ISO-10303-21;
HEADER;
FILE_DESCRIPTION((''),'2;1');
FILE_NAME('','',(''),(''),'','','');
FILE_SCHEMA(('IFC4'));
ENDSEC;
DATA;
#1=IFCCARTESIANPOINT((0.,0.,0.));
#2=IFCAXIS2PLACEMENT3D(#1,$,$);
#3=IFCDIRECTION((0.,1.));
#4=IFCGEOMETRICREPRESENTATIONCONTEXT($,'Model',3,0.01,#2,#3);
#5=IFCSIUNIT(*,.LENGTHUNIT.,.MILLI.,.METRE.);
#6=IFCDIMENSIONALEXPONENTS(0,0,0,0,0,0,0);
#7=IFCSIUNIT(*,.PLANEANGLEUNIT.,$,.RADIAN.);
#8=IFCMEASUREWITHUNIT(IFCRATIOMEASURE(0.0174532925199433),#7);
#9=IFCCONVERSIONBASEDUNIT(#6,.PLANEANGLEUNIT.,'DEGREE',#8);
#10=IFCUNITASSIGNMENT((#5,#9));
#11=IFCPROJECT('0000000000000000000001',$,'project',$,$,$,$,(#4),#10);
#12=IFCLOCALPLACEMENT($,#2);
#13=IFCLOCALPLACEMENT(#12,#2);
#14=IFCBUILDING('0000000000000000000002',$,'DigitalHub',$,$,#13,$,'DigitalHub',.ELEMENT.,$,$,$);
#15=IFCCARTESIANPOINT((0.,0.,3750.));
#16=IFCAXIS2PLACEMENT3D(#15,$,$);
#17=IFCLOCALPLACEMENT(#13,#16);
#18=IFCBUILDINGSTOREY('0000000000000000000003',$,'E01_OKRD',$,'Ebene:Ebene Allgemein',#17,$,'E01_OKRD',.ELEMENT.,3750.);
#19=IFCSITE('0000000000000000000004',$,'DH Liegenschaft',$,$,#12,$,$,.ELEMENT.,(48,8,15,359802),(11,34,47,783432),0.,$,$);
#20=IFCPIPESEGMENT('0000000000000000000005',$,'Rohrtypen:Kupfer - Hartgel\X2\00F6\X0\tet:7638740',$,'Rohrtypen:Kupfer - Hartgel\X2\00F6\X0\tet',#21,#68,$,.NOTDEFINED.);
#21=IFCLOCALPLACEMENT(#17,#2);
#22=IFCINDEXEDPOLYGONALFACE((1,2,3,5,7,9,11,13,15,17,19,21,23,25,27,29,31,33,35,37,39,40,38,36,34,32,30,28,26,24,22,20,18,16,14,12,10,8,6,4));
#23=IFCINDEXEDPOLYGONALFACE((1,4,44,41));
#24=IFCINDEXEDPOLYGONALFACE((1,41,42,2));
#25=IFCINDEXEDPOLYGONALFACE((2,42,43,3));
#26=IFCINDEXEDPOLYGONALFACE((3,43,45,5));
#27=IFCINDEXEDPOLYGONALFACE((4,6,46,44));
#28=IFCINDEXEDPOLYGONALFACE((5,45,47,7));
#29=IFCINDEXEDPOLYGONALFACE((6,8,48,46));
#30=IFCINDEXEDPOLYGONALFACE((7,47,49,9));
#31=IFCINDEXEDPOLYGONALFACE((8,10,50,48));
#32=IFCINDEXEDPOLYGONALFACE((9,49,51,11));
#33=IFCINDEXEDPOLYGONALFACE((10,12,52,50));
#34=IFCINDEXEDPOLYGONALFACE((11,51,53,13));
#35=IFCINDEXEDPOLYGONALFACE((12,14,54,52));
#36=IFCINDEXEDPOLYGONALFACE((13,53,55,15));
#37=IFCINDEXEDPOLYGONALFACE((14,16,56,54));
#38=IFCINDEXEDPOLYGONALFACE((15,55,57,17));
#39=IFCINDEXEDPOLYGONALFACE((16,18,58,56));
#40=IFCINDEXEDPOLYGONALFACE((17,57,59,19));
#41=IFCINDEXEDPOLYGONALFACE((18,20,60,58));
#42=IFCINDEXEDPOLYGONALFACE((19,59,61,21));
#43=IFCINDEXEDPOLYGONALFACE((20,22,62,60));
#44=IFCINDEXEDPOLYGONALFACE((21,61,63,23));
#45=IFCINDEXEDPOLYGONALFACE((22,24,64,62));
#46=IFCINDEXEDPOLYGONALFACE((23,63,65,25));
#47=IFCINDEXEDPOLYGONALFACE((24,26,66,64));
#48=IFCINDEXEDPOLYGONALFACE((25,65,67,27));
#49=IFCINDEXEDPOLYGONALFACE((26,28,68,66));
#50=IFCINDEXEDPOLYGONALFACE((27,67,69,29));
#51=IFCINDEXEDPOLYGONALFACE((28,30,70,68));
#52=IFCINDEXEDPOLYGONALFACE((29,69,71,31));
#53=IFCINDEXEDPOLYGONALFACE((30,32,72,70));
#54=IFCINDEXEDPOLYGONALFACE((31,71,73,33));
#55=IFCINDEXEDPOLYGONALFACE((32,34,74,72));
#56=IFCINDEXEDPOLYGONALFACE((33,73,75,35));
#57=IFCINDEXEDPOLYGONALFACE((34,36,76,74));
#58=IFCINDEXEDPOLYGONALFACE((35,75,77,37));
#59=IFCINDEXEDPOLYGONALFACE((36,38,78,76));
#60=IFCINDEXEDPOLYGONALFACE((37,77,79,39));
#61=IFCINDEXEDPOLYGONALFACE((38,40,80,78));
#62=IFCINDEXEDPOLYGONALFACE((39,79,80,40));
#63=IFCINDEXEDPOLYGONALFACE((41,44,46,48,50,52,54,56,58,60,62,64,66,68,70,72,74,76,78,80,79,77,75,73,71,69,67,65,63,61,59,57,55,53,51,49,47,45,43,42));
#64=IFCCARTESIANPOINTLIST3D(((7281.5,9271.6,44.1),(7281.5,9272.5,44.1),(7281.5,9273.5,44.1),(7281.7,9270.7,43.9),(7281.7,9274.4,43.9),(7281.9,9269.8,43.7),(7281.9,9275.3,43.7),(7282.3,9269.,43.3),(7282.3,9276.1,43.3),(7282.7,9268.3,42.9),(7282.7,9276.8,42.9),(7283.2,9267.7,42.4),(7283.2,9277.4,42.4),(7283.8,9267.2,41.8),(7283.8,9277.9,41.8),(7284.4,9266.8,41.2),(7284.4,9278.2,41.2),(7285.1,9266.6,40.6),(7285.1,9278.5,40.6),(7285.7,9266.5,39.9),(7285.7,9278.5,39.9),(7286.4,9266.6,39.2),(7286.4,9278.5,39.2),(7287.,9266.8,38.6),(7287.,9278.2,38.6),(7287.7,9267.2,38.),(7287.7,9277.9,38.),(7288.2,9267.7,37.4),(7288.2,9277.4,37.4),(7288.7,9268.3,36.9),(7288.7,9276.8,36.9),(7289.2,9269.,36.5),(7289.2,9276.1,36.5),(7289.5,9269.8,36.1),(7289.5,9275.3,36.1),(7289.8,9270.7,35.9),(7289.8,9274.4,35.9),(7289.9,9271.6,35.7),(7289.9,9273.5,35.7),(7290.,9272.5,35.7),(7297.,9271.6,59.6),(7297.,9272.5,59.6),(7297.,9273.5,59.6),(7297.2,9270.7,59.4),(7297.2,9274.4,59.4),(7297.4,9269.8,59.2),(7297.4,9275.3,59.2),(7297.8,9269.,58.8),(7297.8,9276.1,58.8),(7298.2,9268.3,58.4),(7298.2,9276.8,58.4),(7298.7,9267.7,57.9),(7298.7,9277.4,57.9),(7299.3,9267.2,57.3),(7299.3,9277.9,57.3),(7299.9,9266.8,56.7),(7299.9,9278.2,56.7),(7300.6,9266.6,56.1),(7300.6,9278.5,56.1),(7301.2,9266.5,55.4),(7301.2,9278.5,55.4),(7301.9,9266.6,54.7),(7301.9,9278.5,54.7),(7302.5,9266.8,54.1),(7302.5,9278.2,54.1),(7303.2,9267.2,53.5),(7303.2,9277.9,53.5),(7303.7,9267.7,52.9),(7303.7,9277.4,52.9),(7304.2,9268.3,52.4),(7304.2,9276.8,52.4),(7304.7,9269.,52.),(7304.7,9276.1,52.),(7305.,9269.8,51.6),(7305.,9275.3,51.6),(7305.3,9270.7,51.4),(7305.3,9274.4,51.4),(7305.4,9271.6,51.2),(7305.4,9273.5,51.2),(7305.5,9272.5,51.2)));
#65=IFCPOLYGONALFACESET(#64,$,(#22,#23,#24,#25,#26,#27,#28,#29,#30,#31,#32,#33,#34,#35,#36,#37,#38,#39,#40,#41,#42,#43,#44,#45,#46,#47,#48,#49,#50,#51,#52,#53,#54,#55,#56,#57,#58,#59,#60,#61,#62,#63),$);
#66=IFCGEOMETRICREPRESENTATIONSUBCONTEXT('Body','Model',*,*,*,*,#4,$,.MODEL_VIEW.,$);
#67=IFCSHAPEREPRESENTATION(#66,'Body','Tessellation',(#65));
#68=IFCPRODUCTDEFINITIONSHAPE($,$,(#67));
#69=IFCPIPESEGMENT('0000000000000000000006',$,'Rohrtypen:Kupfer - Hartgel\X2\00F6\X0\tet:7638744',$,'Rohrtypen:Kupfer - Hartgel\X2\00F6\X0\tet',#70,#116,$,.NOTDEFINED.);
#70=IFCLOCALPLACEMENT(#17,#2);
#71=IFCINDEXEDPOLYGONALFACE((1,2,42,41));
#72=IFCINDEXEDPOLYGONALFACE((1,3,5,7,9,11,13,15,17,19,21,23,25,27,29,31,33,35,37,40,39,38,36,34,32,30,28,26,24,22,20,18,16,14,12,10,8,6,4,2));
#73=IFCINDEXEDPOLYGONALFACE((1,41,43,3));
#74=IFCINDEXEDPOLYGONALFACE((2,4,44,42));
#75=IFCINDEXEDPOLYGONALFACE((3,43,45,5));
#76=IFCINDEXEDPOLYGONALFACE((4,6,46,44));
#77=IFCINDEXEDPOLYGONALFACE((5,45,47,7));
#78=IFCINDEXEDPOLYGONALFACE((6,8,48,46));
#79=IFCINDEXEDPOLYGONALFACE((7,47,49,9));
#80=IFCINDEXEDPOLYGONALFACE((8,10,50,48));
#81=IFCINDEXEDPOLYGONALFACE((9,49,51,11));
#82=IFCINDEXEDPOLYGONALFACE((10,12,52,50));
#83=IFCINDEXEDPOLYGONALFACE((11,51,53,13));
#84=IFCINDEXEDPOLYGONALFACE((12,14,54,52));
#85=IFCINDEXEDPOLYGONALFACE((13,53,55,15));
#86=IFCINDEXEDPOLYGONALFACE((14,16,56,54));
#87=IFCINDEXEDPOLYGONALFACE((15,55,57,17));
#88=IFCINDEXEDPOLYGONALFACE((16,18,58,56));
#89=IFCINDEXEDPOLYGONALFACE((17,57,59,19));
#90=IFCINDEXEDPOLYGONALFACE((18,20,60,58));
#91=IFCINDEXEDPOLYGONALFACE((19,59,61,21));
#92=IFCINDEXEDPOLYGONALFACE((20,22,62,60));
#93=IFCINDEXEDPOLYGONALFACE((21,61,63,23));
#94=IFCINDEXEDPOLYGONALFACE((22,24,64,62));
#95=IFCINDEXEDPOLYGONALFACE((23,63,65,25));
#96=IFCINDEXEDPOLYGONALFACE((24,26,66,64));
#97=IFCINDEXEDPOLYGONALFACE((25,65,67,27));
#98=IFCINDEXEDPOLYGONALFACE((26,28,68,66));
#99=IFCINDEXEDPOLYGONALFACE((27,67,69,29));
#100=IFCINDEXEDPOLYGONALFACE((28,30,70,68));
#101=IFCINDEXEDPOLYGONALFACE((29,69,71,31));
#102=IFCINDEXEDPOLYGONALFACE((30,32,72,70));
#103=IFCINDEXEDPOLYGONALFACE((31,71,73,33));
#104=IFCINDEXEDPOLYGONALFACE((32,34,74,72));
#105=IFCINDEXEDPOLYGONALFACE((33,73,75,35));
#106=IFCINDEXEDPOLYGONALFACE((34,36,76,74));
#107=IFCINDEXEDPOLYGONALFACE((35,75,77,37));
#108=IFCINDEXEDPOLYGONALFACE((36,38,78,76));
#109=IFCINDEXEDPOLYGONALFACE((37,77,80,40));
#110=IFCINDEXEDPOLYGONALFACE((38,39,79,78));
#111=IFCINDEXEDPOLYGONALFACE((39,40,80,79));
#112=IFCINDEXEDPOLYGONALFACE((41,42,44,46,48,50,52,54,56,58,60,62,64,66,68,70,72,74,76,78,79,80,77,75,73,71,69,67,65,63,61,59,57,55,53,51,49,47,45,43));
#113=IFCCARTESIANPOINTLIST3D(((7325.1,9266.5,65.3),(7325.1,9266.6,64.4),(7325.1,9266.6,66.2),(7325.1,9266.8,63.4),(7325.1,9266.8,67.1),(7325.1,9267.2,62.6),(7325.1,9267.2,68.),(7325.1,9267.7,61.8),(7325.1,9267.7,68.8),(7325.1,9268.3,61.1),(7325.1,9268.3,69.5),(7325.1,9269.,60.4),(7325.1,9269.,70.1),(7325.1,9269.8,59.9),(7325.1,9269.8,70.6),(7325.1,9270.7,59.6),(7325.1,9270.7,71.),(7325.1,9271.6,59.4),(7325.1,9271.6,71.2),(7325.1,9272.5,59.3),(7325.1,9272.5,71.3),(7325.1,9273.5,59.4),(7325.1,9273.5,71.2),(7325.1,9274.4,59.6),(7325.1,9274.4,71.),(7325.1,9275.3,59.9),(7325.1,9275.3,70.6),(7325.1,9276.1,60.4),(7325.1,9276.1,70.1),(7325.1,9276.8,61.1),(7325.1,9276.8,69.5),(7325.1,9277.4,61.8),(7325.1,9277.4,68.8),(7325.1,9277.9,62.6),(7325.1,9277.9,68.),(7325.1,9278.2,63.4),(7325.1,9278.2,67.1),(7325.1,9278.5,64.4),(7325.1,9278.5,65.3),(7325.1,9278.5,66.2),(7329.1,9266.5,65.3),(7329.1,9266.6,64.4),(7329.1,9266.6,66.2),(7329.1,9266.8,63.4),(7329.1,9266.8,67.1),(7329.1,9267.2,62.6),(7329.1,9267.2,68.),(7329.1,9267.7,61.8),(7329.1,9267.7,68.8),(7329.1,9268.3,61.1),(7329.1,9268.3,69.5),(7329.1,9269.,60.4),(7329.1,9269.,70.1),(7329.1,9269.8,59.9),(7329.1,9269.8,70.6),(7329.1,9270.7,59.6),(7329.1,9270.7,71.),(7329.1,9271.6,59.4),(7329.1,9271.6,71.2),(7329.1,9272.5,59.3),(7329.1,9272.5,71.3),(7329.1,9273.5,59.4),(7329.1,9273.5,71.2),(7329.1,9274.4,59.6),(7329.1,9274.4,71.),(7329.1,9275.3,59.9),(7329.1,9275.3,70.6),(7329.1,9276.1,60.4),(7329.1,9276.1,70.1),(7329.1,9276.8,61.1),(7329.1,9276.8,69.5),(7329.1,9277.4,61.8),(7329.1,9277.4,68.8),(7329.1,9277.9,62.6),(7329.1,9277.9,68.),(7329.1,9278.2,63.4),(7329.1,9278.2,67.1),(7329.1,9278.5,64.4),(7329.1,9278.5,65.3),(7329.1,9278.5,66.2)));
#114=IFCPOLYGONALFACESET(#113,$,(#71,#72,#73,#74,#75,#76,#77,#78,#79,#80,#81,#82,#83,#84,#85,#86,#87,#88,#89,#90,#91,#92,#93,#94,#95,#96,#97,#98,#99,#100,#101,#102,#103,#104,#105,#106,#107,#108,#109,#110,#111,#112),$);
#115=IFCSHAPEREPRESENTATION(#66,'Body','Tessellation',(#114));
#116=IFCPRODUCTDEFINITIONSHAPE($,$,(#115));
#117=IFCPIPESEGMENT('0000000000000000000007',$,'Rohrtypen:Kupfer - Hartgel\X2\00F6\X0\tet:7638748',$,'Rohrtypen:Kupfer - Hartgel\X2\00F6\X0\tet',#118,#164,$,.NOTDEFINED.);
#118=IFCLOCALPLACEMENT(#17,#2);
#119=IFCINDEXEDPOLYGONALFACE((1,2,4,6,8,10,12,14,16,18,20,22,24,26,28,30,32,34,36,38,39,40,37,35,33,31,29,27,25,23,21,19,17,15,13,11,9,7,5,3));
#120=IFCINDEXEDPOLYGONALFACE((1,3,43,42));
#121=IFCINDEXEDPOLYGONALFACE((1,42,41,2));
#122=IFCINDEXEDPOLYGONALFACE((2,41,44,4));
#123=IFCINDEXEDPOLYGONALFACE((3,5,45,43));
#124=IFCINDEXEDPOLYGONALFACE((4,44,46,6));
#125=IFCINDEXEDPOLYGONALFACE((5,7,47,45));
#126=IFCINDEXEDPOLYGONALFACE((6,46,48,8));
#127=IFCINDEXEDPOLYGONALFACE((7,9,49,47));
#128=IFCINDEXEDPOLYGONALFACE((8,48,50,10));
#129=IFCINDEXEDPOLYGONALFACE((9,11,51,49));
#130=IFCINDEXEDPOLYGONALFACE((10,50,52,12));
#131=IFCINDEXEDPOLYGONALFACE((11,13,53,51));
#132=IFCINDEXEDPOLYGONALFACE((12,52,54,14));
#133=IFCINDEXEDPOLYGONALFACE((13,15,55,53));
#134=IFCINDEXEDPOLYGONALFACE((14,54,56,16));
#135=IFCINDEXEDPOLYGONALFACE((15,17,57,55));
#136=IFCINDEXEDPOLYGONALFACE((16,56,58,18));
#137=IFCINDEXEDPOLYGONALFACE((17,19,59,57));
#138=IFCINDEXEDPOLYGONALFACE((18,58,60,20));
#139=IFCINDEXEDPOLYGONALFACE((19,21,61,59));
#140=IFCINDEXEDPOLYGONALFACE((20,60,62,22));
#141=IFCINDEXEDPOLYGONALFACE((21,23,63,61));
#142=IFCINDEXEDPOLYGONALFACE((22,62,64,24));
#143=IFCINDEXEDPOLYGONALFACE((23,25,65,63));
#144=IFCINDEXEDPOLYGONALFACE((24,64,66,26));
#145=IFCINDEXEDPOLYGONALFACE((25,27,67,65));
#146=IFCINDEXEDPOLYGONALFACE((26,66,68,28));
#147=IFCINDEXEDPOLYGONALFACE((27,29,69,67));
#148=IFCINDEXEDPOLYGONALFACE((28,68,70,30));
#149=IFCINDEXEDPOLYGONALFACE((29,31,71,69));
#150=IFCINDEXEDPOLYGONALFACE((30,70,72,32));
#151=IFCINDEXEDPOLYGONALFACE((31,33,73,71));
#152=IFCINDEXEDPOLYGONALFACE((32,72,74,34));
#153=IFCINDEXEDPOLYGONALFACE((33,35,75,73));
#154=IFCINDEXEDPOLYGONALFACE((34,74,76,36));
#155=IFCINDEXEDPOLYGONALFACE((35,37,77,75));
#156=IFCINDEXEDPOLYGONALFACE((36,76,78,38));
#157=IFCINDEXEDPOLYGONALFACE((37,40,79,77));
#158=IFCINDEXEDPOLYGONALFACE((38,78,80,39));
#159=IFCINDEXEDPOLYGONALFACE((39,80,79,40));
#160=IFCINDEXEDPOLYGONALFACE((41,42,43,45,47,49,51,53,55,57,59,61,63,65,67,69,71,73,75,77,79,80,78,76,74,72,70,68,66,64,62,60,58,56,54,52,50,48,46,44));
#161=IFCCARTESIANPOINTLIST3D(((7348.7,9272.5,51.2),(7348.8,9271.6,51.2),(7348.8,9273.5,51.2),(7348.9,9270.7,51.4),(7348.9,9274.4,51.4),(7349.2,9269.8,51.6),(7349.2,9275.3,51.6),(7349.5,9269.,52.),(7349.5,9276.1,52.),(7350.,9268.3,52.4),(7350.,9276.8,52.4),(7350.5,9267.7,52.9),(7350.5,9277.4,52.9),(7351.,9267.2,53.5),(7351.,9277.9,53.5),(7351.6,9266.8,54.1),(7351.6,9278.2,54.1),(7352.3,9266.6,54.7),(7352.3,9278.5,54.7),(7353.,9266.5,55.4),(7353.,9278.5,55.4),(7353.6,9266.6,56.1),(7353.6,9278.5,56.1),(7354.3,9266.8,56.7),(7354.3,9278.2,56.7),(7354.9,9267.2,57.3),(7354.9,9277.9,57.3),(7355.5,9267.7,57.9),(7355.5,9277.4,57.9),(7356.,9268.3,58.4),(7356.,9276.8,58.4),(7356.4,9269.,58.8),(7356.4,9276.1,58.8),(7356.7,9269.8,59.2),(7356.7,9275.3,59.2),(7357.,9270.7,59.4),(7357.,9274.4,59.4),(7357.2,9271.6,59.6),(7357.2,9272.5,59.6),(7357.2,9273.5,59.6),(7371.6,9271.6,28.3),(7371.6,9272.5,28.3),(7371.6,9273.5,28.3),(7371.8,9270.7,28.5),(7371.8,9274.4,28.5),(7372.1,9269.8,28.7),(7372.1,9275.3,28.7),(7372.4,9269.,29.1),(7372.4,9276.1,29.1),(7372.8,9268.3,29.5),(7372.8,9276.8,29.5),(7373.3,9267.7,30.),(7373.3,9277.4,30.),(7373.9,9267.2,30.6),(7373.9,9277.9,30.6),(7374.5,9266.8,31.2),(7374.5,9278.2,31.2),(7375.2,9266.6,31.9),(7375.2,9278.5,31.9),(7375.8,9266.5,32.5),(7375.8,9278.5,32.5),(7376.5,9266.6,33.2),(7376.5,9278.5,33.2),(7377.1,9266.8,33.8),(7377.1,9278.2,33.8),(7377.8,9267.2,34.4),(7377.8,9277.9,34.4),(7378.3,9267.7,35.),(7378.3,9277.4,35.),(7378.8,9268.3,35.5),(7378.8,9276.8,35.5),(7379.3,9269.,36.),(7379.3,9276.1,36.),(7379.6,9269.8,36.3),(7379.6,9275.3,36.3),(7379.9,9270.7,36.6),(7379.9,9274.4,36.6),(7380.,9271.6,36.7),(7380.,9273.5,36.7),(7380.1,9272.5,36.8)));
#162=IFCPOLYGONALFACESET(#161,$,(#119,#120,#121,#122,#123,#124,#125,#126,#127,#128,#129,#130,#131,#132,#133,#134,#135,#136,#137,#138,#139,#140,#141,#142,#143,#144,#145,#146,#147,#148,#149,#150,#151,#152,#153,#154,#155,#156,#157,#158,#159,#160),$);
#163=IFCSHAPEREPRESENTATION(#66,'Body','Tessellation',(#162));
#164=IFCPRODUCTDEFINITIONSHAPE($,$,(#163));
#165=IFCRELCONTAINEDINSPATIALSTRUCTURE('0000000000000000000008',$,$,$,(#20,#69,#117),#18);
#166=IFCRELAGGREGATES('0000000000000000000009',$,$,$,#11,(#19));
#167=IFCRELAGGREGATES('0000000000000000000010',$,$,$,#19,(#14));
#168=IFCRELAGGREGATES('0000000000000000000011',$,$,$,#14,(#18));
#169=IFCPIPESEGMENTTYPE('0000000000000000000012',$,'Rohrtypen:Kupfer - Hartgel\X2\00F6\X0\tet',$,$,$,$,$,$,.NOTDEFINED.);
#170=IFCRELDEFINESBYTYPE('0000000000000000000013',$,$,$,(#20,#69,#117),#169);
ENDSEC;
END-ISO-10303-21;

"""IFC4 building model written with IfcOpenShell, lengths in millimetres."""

from ifc_helpers import new_model, entity, si_unit, converted_unit, direction, frame, origin, place, context, subcontext, project, spatial, indexed_curve, outline, extrude, type_object, element, save


model = new_model("IFC4")

# Units and contexts
model_context = context("Model", 3, precision=0.01, world=origin(), true_north=direction((0.0, 1.0)))
body_context = subcontext(model_context, "Body", "Model", "MODEL_VIEW")
ifc_project = project(units=[si_unit("LENGTHUNIT", "METRE", prefix="MILLI"), converted_unit("PLANEANGLEUNIT", "DEGREE", entity("IfcRatioMeasure", 0.0174532925199433), si_unit("PLANEANGLEUNIT", "RADIAN"), dimensions=[0, 0, 0, 0, 0, 0, 0])], contexts=[model_context])

# Site, building, storey
site_placement = place(None, origin())
site = spatial("IfcSite", under=ifc_project, at=site_placement, Name="DH Liegenschaft", CompositionType="ELEMENT", RefLatitude=(48, 8, 15, 359802), RefLongitude=(11, 34, 47, 783432), RefElevation=0.0)
building_placement = place(site_placement, origin())
building = spatial("IfcBuilding", under=site, at=building_placement, Name="DigitalHub", LongName="DigitalHub", CompositionType="ELEMENT")
storey_placement = place(building_placement, frame((0.0, 0.0, 3750.0)))
storey = spatial("IfcBuildingStorey", under=building, at=storey_placement, Name="E01_OKRD", ObjectType="Ebene:Ebene Allgemein", LongName="E01_OKRD", CompositionType="ELEMENT", Elevation=3750.0)

# Pipe segments
pipe_segment_type = type_object("IfcPipeSegmentType", Name="Rohrtypen:Kupfer - Hartgelötet", PredefinedType="NOTDEFINED")
pipe_segment_1_placement = place(storey_placement, frame((7279.9, 9264.9, 34.1)))
element("IfcPipeSegment", 1, at=pipe_segment_1_placement, inside=storey, type_object=pipe_segment_type, Name="Rohrtypen:Kupfer - Hartgelötet:7638740", ObjectType="Rohrtypen:Kupfer - Hartgelötet", PredefinedType="NOTDEFINED", context=body_context, shape_type="SweptSolid", body=[
    extrude(outline(indexed_curve([(6.0, 0.0), (5.9, 0.9), (5.7, 1.9), (5.3, 2.7), (4.9, 3.5), (4.2, 4.2), (3.5, 4.9), (2.7, 5.3), (1.9, 5.7), (0.9, 5.9), (0.0, 6.0), (-0.9, 5.9), (-1.9, 5.7), (-2.7, 5.3), (-3.5, 4.9), (-4.2, 4.2), (-4.9, 3.5), (-5.3, 2.7), (-5.7, 1.9), (-5.9, 0.9), (-6.0, 0.0), (-5.9, -0.9), (-5.7, -1.9), (-5.3, -2.7), (-4.9, -3.5), (-4.2, -4.2), (-3.5, -4.9), (-2.7, -5.3), (-1.9, -5.7), (-0.9, -5.9), (0.0, -6.0), (0.9, -5.9), (1.9, -5.7), (2.7, -5.3), (3.5, -4.9), (4.2, -4.2), (4.9, -3.5), (5.3, -2.7), (5.7, -1.9), (5.9, -0.9), (6.0, 0.0)], self_intersect=False)), frame((5.8, 7.6, 5.8), z_axis=(0.707107, 0.0, 0.707107), x_axis=(0.0, -1.0, 0.0)), (0.0, 0.0, 1.0), 21.9),
])
pipe_segment_2_placement = place(storey_placement, frame((7325.1, 9264.9, 57.7)))
element("IfcPipeSegment", 2, at=pipe_segment_2_placement, inside=storey, type_object=pipe_segment_type, Name="Rohrtypen:Kupfer - Hartgelötet:7638744", ObjectType="Rohrtypen:Kupfer - Hartgelötet", PredefinedType="NOTDEFINED", context=body_context, shape_type="SweptSolid", body=[
    extrude(outline(indexed_curve([(6.0, 0.0), (5.9, 0.9), (5.7, 1.9), (5.3, 2.7), (4.9, 3.5), (4.2, 4.2), (3.5, 4.9), (2.7, 5.3), (1.9, 5.7), (0.9, 5.9), (0.0, 6.0), (-0.9, 5.9), (-1.9, 5.7), (-2.7, 5.3), (-3.5, 4.9), (-4.2, 4.2), (-4.9, 3.5), (-5.3, 2.7), (-5.7, 1.9), (-5.9, 0.9), (-6.0, 0.0), (-5.9, -0.9), (-5.7, -1.9), (-5.3, -2.7), (-4.9, -3.5), (-4.2, -4.2), (-3.5, -4.9), (-2.7, -5.3), (-1.9, -5.7), (-0.9, -5.9), (0.0, -6.0), (0.9, -5.9), (1.9, -5.7), (2.7, -5.3), (3.5, -4.9), (4.2, -4.2), (4.9, -3.5), (5.3, -2.7), (5.7, -1.9), (5.9, -0.9), (6.0, 0.0)], self_intersect=False)), frame((0.0, 7.6, 7.6), z_axis=(1.0, 0.000746, 0.0), x_axis=(0.000746, -1.0, 0.0)), (0.0, 0.0, 1.0), 3.9),
])
pipe_segment_3_placement = place(storey_placement, frame((7347.1, 9264.9, 26.7)))
element("IfcPipeSegment", 3, at=pipe_segment_3_placement, inside=storey, type_object=pipe_segment_type, Name="Rohrtypen:Kupfer - Hartgelötet:7638748", ObjectType="Rohrtypen:Kupfer - Hartgelötet", PredefinedType="NOTDEFINED", context=body_context, shape_type="SweptSolid", body=[
    extrude(outline(indexed_curve([(6.0, 0.0), (5.9, 0.9), (5.7, 1.9), (5.3, 2.7), (4.9, 3.5), (4.2, 4.2), (3.5, 4.9), (2.7, 5.3), (1.9, 5.7), (0.9, 5.9), (0.0, 6.0), (-0.9, 5.9), (-1.9, 5.7), (-2.7, 5.3), (-3.5, 4.9), (-4.2, 4.2), (-4.9, 3.5), (-5.3, 2.7), (-5.7, 1.9), (-5.9, 0.9), (-6.0, 0.0), (-5.9, -0.9), (-5.7, -1.9), (-5.3, -2.7), (-4.9, -3.5), (-4.2, -4.2), (-3.5, -4.9), (-2.7, -5.3), (-1.9, -5.7), (-0.9, -5.9), (0.0, -6.0), (0.9, -5.9), (1.9, -5.7), (2.7, -5.3), (3.5, -4.9), (4.2, -4.2), (4.9, -3.5), (5.3, -2.7), (5.7, -1.9), (5.9, -0.9), (6.0, 0.0)], self_intersect=False)), frame((28.7, 7.6, 5.8), z_axis=(-0.707107, 0.0, 0.707107), x_axis=(0.0, -1.0, 0.0)), (0.0, 0.0, 1.0), 32.3),
])

save(model, "model.ifc")
